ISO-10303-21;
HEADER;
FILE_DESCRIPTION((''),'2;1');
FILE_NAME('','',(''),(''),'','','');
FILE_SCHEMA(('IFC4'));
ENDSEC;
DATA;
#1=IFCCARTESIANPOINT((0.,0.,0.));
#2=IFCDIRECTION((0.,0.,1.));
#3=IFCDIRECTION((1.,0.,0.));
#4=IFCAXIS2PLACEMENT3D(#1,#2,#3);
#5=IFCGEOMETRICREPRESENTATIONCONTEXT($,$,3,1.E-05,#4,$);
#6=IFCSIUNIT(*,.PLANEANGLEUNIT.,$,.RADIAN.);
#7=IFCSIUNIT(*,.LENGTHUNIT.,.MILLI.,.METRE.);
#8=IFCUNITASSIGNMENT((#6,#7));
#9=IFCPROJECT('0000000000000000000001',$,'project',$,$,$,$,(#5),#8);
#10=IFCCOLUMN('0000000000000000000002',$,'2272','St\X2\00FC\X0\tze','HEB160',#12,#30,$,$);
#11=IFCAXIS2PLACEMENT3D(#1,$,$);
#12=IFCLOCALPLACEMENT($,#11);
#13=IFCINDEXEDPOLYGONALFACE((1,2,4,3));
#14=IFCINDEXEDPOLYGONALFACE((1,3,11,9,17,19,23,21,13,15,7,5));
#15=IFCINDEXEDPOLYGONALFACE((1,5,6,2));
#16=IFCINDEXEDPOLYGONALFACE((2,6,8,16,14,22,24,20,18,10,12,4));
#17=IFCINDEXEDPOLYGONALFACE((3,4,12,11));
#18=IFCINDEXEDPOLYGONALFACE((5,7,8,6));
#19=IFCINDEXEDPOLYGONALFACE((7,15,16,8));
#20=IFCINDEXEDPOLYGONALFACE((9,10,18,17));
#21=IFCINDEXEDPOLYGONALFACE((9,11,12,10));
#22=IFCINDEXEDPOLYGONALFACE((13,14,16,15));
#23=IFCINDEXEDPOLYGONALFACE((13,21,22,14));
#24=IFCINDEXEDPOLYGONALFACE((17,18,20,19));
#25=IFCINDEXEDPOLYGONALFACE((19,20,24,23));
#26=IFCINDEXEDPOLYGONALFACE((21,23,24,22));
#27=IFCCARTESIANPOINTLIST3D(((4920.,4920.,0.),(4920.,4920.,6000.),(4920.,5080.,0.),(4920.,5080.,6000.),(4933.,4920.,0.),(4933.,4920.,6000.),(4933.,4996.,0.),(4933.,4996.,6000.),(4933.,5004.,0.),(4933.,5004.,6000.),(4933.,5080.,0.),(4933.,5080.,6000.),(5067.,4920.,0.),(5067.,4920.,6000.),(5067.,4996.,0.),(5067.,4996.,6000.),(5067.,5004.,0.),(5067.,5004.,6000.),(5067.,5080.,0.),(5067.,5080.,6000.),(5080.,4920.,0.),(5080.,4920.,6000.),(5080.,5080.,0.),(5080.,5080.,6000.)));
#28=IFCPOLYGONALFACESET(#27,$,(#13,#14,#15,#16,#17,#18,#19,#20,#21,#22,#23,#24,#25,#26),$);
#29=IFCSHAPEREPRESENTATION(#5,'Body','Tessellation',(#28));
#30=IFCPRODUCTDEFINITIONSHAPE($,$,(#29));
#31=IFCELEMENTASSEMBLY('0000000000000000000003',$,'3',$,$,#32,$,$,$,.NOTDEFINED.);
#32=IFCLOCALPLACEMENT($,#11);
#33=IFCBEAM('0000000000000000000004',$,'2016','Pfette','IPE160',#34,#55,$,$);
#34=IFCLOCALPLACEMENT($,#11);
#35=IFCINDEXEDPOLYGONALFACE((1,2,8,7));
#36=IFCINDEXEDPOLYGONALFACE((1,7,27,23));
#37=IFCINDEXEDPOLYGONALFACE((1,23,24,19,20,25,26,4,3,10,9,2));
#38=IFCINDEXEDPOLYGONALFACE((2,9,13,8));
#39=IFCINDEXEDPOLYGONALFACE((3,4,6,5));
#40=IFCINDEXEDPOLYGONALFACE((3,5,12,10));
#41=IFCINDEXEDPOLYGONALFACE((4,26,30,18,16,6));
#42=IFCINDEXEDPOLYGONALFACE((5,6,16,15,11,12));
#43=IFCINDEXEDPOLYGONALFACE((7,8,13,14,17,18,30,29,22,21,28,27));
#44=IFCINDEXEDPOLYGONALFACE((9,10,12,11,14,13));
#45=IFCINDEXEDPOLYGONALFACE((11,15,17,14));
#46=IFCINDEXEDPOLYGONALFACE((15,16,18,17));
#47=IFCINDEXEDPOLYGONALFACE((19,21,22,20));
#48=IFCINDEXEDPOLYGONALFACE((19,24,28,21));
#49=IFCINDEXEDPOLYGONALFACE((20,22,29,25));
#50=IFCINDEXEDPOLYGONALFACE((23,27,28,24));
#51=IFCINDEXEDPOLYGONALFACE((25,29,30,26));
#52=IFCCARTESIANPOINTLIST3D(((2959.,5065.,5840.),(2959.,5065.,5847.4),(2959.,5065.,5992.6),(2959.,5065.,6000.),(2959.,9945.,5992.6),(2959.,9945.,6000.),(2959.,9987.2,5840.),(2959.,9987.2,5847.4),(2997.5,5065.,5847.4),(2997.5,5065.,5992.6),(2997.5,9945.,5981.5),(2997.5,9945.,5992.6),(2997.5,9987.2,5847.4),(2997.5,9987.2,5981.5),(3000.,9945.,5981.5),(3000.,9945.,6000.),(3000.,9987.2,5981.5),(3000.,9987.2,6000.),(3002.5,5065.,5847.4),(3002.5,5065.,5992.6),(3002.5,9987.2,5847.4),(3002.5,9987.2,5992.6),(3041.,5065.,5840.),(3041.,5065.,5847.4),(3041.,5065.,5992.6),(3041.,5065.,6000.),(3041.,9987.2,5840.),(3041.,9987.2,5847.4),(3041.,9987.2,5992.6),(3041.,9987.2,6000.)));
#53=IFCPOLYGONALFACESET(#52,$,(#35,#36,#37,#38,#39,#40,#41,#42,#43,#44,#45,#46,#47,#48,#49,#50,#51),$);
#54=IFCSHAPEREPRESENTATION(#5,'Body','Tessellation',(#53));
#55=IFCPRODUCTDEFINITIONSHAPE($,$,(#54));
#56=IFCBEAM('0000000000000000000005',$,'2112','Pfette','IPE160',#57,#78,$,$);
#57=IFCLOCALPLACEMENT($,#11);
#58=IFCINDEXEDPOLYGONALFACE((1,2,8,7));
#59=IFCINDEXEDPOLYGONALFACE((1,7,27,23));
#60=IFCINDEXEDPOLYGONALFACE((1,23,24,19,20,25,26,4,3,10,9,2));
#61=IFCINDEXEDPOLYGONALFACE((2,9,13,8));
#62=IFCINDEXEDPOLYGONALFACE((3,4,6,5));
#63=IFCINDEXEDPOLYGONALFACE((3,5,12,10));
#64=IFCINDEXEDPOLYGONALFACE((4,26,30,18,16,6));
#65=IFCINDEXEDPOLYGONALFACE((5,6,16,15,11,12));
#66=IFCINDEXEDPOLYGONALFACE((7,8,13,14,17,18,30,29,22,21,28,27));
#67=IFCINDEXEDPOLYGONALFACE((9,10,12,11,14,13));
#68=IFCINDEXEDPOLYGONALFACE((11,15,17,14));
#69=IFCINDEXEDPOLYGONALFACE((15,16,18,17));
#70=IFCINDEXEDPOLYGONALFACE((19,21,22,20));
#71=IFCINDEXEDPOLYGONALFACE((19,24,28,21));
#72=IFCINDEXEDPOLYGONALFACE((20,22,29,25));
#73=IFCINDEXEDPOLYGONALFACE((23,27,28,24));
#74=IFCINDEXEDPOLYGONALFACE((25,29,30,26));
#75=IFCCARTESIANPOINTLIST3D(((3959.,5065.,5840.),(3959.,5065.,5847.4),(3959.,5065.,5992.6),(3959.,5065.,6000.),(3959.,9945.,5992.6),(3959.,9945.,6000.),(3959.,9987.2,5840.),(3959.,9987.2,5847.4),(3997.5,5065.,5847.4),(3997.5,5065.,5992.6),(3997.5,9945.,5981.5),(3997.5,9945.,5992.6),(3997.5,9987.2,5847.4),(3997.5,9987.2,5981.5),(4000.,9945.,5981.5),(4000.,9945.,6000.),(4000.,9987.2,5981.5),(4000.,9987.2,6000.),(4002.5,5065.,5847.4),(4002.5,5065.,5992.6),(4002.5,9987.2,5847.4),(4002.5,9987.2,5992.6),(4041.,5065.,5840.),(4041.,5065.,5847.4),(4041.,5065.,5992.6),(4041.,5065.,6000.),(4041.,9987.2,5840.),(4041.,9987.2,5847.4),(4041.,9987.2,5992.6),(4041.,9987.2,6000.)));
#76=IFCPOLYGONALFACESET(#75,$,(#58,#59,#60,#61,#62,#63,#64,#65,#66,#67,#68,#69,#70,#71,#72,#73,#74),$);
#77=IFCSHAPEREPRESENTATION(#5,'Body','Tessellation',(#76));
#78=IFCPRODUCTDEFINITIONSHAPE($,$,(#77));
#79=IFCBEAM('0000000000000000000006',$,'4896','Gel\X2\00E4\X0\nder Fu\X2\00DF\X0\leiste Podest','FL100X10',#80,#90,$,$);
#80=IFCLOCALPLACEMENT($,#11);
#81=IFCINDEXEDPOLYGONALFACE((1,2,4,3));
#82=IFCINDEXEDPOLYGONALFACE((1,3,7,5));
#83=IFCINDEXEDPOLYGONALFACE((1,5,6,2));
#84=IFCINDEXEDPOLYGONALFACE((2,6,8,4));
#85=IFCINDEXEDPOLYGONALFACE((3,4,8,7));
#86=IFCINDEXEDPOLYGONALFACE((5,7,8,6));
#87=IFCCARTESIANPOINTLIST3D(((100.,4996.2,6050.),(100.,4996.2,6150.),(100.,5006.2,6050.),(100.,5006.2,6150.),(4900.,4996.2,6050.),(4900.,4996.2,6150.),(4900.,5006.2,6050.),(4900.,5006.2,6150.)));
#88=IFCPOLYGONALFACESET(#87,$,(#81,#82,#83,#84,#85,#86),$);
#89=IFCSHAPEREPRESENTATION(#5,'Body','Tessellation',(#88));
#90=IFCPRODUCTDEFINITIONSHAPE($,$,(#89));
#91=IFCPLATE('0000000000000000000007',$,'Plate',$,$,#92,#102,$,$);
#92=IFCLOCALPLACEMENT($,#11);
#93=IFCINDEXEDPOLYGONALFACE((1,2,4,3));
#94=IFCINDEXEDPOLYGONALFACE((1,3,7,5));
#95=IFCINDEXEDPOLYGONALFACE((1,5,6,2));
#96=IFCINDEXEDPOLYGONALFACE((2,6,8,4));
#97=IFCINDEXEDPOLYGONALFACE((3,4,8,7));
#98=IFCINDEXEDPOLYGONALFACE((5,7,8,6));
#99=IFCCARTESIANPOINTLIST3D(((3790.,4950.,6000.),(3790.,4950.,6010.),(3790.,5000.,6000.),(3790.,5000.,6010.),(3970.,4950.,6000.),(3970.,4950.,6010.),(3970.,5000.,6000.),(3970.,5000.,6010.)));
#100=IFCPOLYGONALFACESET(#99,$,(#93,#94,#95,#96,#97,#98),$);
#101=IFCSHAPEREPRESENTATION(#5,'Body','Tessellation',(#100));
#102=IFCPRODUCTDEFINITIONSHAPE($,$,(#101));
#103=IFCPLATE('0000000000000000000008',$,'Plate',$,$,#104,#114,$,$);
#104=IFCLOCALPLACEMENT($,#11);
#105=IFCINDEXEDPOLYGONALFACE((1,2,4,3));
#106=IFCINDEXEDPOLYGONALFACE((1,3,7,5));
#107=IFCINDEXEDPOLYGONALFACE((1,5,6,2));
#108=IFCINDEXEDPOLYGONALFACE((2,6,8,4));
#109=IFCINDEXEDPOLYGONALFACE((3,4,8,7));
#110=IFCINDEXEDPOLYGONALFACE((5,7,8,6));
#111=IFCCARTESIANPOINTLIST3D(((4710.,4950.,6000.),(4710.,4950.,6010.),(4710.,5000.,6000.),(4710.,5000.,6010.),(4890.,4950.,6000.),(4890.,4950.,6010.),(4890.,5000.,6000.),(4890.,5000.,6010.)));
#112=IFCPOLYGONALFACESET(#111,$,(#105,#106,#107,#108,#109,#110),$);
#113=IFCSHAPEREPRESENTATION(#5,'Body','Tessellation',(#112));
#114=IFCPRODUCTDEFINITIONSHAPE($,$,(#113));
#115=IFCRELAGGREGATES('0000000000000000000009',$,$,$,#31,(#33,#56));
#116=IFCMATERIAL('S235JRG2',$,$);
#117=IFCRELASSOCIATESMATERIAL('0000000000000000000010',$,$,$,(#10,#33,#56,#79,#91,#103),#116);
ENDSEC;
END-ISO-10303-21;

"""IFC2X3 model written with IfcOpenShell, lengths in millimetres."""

from ifc_helpers import new_model, si_unit, point, frame, origin_with_axes, place, context, project, polyline, line_curve, trimmed, segment, composite_curve, outline, extrude, clip, halfspace, material, element, aggregate, save


model = new_model("IFC2X3")

# Units and contexts
context_of_model = context(None, 3, precision=1e-05, world=origin_with_axes())
ifc_project = project(units=[si_unit("PLANEANGLEUNIT", "RADIAN"), si_unit("LENGTHUNIT", "METRE", prefix="MILLI")], contexts=[context_of_model])

# Column
ifc_material = material(Name="S235JRG2")
placement_1 = place(None, frame((5000.0, 5000.0, 6000.0), z_axis=(1.0, 0.0, 0.0), x_axis=(0.0, 0.0, -1.0)))
column_placement = place(placement_1, origin_with_axes())
element("IfcColumn", 1, at=column_placement, material=ifc_material, Name="2272", Description="Stütze", ObjectType="HEB160", context=context_of_model, shape_type="Clipping", body=[
    clip(extrude(outline(polyline([(80.0, -80.0), (80.0, -67.0), (4.0, -67.0), (4.0, 67.0), (80.0, 67.0), (80.0, 80.0), (-80.0, 80.0), (-80.0, 67.0), (-4.0, 67.0), (-4.0, -67.0), (-80.0, -67.0), (-80.0, -80.0), (80.0, -80.0), (80.0, -80.0)])), frame((0.0, 0.0, 0.0), z_axis=(1.0, 0.0, 0.0), x_axis=(0.0, 1.0, 0.0)), (0.0, 0.0, 1.0), 6000.0), halfspace(frame((6000.0, 0.0, 0.0), z_axis=(1.0, 0.0, 0.0), x_axis=(0.0, 0.0, 1.0)), False)),
])

# Element assembly, beams, openings
assembly_placement = place(None, frame((1000.0, 5002.5, 6000.0), z_axis=(0.0, 0.0, 1.0), x_axis=(0.0, 1.0, 0.0)))
assembly = element("IfcElementAssembly", 2, at=assembly_placement, Name="3", PredefinedType="NOTDEFINED")
placement_2 = place(None, frame((3000.0, 5002.5, 5920.0), z_axis=(0.0, 0.0, 1.0), x_axis=(0.0, 1.0, 0.0)))
beam_1_placement = place(placement_2, origin_with_axes())
beam_1 = element("IfcBeam", 3, at=beam_1_placement, material=ifc_material, Name="2016", Description="Pfette", ObjectType="IPE160", context=context_of_model, shape_type="Clipping", body=[
    clip(clip(extrude(outline(polyline([(41.0, -80.0), (41.0, -72.6), (2.5, -72.6), (2.5, 72.6), (41.0, 72.6), (41.0, 80.0), (-41.0, 80.0), (-41.0, 72.6), (-2.5, 72.6), (-2.5, -72.6), (-41.0, -72.6), (-41.0, -80.0), (41.0, -80.0), (41.0, -80.0)])), frame((0.0, 0.0, 0.0), z_axis=(1.0, 0.0, 0.0), x_axis=(0.0, 1.0, 0.0)), (0.0, 0.0, 1.0), 4997.5), halfspace(frame((62.5, 0.0, 80.0), z_axis=(-1.0, 0.0, 0.0), x_axis=(0.0, 0.0, -1.0)), False)), halfspace(frame((4984.7, 0.0, 80.0), z_axis=(1.0, 0.0, 0.0), x_axis=(0.0, 0.0, 1.0)), False)),
])
opening_1_placement = place(beam_1_placement, frame((4942.5, 0.0, 61.5), z_axis=(0.0, 1.0, 0.0), x_axis=(-1.0, 0.0, 0.0)))
element("IfcOpeningElement", 4, at=opening_1_placement, cuts=beam_1, ObjectType="Recess", context=context_of_model, shape_type="SweptSolid", body=[
    extrude(outline(composite_curve([segment(trimmed(line_curve((0.0, 0.0), (0.0, 1.0, 0.0), 18.501), [point((0.0, 0.0))], [point((0.0, 18.5))], True, "CARTESIAN"), True, "CONTINUOUS"), segment(trimmed(line_curve((0.0, 18.5), (-1.0, 0.0, 0.0), 42.201), [point((0.0, 18.5))], [point((-42.2, 18.5))], True, "CARTESIAN"), True, "CONTINUOUS"), segment(trimmed(line_curve((-42.2, 18.5), (0.0, -1.0, 0.0), 18.501), [point((-42.2, 18.5))], [point((-42.2, 0.0))], True, "CARTESIAN"), True, "CONTINUOUS"), segment(trimmed(line_curve((-42.2, 0.0), (1.0, 0.0, 0.0), 42.201), [point((-42.2, 0.0))], [point((0.0, 0.0))], True, "CARTESIAN"), True, "CONTINUOUS")], self_intersect=False)), origin_with_axes(), (0.0, 0.0, 1.0), 3000.0),
])
placement_3 = place(None, frame((4000.0, 5002.5, 5920.0), z_axis=(0.0, 0.0, 1.0), x_axis=(0.0, 1.0, 0.0)))
beam_2_placement = place(placement_3, origin_with_axes())
beam_2 = element("IfcBeam", 5, at=beam_2_placement, material=ifc_material, Name="2112", Description="Pfette", ObjectType="IPE160", context=context_of_model, shape_type="Clipping", body=[
    clip(clip(extrude(outline(polyline([(41.0, -80.0), (41.0, -72.6), (2.5, -72.6), (2.5, 72.6), (41.0, 72.6), (41.0, 80.0), (-41.0, 80.0), (-41.0, 72.6), (-2.5, 72.6), (-2.5, -72.6), (-41.0, -72.6), (-41.0, -80.0), (41.0, -80.0), (41.0, -80.0)])), frame((0.0, 0.0, 0.0), z_axis=(1.0, 0.0, 0.0), x_axis=(0.0, 1.0, 0.0)), (0.0, 0.0, 1.0), 4997.5), halfspace(frame((62.5, 0.0, 80.0), z_axis=(-1.0, 0.0, 0.0), x_axis=(0.0, 0.0, -1.0)), False)), halfspace(frame((4984.7, 0.0, 80.0), z_axis=(1.0, 0.0, 0.0), x_axis=(0.0, 0.0, 1.0)), False)),
])
opening_2_placement = place(beam_2_placement, frame((4942.5, 0.0, 61.5), z_axis=(0.0, 1.0, 0.0), x_axis=(-1.0, 0.0, 0.0)))
element("IfcOpeningElement", 6, at=opening_2_placement, cuts=beam_2, ObjectType="Recess", context=context_of_model, shape_type="SweptSolid", body=[
    extrude(outline(composite_curve([segment(trimmed(line_curve((0.0, 0.0), (0.0, 1.0, 0.0), 18.501), [point((0.0, 0.0))], [point((0.0, 18.5))], True, "CARTESIAN"), True, "CONTINUOUS"), segment(trimmed(line_curve((0.0, 18.5), (-1.0, 0.0, 0.0), 42.201), [point((0.0, 18.5))], [point((-42.2, 18.5))], True, "CARTESIAN"), True, "CONTINUOUS"), segment(trimmed(line_curve((-42.2, 18.5), (0.0, -1.0, 0.0), 18.501), [point((-42.2, 18.5))], [point((-42.2, 0.0))], True, "CARTESIAN"), True, "CONTINUOUS"), segment(trimmed(line_curve((-42.2, 0.0), (1.0, 0.0, 0.0), 42.201), [point((-42.2, 0.0))], [point((0.0, 0.0))], True, "CARTESIAN"), True, "CONTINUOUS")], self_intersect=False)), origin_with_axes(), (0.0, 0.0, 1.0), 3000.0),
])
aggregate(assembly, [beam_1, beam_2])

# Beam
placement_4 = place(None, frame((4900.0, 5001.2, 6100.0), z_axis=(0.0, 0.0, 1.0), x_axis=(-1.0, 0.0, 0.0)))
beam_3_placement = place(placement_4, origin_with_axes())
element("IfcBeam", 7, at=beam_3_placement, material=ifc_material, Name="4896", Description="Geländer Fußleiste Podest", ObjectType="FL100X10", context=context_of_model, shape_type="SweptSolid", body=[
    extrude(outline(polyline([(5.0, -50.0), (5.0, 50.0), (-5.0, 50.0), (-5.0, -50.0), (5.0, -50.0), (5.0, -50.0)])), frame((0.0, 0.0, 0.0), z_axis=(1.0, 0.0, 0.0), x_axis=(0.0, 1.0, 0.0)), (0.0, 0.0, 1.0), 4800.0),
])

# Plates
placement_5 = place(None, origin_with_axes())
plate_1_placement = place(placement_5, frame((3790.0, 5000.0, 6010.0), z_axis=(0.0, -1.0, 0.0), x_axis=(0.0, 0.0, -1.0)))
element("IfcPlate", 8, at=plate_1_placement, material=ifc_material, Name="Plate", context=context_of_model, shape_type="SweptSolid", body=[
    extrude(outline(polyline([(0.0, 0.0), (180.0, 0.0), (180.0, 50.0), (0.0, 50.0), (0.0, 0.0)])), frame((0.0, 0.0, 0.0), z_axis=(1.0, 0.0, 0.0), x_axis=(0.0, 1.0, 0.0)), (0.0, 0.0, 1.0), 10.0),
])
placement_6 = place(None, origin_with_axes())
plate_2_placement = place(placement_6, frame((4710.0, 5000.0, 6010.0), z_axis=(0.0, -1.0, 0.0), x_axis=(0.0, 0.0, -1.0)))
element("IfcPlate", 9, at=plate_2_placement, material=ifc_material, Name="Plate", context=context_of_model, shape_type="SweptSolid", body=[
    extrude(outline(polyline([(0.0, 0.0), (180.0, 0.0), (180.0, 50.0), (0.0, 50.0), (0.0, 0.0)])), frame((0.0, 0.0, 0.0), z_axis=(1.0, 0.0, 0.0), x_axis=(0.0, 1.0, 0.0)), (0.0, 0.0, 1.0), 10.0),
])

save(model, "model.ifc")
